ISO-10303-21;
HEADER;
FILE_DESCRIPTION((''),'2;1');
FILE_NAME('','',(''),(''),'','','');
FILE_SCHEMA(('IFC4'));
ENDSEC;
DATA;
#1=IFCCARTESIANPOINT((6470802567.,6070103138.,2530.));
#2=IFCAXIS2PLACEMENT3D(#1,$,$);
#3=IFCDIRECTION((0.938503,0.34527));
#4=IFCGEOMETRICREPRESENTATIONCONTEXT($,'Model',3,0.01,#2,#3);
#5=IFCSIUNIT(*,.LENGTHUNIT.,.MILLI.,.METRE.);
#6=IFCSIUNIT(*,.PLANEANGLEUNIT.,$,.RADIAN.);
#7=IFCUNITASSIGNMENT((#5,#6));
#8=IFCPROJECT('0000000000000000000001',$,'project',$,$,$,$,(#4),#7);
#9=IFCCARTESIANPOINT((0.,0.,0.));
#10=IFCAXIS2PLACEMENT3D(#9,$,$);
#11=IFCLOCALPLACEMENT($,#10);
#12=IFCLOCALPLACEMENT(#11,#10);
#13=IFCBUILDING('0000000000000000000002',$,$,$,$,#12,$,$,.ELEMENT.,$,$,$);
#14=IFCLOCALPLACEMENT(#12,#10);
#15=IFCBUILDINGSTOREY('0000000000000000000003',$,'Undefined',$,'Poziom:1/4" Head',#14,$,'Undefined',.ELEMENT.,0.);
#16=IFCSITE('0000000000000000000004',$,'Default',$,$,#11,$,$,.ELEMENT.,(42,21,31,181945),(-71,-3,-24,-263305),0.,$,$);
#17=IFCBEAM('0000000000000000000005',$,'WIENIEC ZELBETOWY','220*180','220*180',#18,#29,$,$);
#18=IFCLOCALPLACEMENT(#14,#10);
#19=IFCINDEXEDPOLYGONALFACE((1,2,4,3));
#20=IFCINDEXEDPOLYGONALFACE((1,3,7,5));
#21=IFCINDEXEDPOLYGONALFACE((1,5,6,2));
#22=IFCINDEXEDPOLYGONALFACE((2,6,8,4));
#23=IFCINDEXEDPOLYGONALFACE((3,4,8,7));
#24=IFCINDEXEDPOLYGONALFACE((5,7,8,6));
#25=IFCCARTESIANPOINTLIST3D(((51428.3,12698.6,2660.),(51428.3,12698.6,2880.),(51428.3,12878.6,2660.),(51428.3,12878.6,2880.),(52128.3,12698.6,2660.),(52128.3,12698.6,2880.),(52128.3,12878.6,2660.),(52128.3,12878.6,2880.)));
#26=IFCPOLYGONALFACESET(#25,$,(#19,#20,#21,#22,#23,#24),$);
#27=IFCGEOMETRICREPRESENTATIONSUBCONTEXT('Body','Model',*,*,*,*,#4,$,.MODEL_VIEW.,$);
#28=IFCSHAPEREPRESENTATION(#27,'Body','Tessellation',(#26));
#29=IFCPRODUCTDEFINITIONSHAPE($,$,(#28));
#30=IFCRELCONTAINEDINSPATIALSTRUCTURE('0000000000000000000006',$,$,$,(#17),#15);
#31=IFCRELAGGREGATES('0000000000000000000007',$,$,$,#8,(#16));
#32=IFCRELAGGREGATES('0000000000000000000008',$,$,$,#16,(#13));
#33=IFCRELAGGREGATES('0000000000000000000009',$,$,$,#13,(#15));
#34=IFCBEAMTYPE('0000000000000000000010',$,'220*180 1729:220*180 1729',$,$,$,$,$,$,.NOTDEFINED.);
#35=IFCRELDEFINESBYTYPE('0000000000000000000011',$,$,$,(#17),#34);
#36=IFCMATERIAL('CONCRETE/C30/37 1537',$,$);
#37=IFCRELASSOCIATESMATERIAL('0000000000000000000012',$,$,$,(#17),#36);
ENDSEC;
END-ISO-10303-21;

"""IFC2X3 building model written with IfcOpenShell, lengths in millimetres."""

from ifc_helpers import new_model, si_unit, direction, frame, frame_2d, origin, place, context, subcontext, project, spatial, rectangle, extrude, material, type_object, element, save


model = new_model("IFC2X3")

# Units and contexts
model_context = context("Model", 3, precision=0.01, world=frame((6470802567.0, 6070103138.0, 2530.0)), true_north=direction((0.938503, 0.34527)))
body_context = subcontext(model_context, "Body", "Model", "MODEL_VIEW")
ifc_project = project(units=[si_unit("LENGTHUNIT", "METRE", prefix="MILLI"), si_unit("PLANEANGLEUNIT", "RADIAN")], contexts=[model_context])

# Site, building, storey
site_placement = place(None, origin())
site = spatial("IfcSite", under=ifc_project, at=site_placement, Name="Default", CompositionType="ELEMENT", RefLatitude=(42, 21, 31, 181945), RefLongitude=(-71, -3, -24, -263305), RefElevation=0.0)
building_placement = place(site_placement, origin())
building = spatial("IfcBuilding", under=site, at=building_placement, CompositionType="ELEMENT")
storey_placement = place(building_placement, origin())
storey = spatial("IfcBuildingStorey", under=building, at=storey_placement, Name="Undefined", ObjectType="Poziom:1/4\" Head", LongName="Undefined", CompositionType="ELEMENT", Elevation=0.0)

# Beam
ifc_material_1 = material(Name="CONCRETE/C30/37 1537")
beam_type_1 = type_object("IfcBeamType", Name="220*180 1729:220*180 1729", PredefinedType="NOTDEFINED")
beam_1_placement = place(storey_placement, origin())
element("IfcBeam", 1, at=beam_1_placement, inside=storey, type_object=beam_type_1, material=ifc_material_1, Name="WIENIEC ZELBETOWY", Description="220*180", ObjectType="220*180", context=body_context, shape_type="SweptSolid", body=[
    extrude(rectangle(XDim=220.0, YDim=180.0, at=frame_2d((0.0, 0.0), x_axis=(1.0, 0.0))), frame((51428.3, 12788.6, 2770.0), z_axis=(1.0, 0.0, 0.0), x_axis=(0.0, 0.0, -1.0)), (0.0, 0.0, 1.0), 700.0),
])

save(model, "model.ifc")
